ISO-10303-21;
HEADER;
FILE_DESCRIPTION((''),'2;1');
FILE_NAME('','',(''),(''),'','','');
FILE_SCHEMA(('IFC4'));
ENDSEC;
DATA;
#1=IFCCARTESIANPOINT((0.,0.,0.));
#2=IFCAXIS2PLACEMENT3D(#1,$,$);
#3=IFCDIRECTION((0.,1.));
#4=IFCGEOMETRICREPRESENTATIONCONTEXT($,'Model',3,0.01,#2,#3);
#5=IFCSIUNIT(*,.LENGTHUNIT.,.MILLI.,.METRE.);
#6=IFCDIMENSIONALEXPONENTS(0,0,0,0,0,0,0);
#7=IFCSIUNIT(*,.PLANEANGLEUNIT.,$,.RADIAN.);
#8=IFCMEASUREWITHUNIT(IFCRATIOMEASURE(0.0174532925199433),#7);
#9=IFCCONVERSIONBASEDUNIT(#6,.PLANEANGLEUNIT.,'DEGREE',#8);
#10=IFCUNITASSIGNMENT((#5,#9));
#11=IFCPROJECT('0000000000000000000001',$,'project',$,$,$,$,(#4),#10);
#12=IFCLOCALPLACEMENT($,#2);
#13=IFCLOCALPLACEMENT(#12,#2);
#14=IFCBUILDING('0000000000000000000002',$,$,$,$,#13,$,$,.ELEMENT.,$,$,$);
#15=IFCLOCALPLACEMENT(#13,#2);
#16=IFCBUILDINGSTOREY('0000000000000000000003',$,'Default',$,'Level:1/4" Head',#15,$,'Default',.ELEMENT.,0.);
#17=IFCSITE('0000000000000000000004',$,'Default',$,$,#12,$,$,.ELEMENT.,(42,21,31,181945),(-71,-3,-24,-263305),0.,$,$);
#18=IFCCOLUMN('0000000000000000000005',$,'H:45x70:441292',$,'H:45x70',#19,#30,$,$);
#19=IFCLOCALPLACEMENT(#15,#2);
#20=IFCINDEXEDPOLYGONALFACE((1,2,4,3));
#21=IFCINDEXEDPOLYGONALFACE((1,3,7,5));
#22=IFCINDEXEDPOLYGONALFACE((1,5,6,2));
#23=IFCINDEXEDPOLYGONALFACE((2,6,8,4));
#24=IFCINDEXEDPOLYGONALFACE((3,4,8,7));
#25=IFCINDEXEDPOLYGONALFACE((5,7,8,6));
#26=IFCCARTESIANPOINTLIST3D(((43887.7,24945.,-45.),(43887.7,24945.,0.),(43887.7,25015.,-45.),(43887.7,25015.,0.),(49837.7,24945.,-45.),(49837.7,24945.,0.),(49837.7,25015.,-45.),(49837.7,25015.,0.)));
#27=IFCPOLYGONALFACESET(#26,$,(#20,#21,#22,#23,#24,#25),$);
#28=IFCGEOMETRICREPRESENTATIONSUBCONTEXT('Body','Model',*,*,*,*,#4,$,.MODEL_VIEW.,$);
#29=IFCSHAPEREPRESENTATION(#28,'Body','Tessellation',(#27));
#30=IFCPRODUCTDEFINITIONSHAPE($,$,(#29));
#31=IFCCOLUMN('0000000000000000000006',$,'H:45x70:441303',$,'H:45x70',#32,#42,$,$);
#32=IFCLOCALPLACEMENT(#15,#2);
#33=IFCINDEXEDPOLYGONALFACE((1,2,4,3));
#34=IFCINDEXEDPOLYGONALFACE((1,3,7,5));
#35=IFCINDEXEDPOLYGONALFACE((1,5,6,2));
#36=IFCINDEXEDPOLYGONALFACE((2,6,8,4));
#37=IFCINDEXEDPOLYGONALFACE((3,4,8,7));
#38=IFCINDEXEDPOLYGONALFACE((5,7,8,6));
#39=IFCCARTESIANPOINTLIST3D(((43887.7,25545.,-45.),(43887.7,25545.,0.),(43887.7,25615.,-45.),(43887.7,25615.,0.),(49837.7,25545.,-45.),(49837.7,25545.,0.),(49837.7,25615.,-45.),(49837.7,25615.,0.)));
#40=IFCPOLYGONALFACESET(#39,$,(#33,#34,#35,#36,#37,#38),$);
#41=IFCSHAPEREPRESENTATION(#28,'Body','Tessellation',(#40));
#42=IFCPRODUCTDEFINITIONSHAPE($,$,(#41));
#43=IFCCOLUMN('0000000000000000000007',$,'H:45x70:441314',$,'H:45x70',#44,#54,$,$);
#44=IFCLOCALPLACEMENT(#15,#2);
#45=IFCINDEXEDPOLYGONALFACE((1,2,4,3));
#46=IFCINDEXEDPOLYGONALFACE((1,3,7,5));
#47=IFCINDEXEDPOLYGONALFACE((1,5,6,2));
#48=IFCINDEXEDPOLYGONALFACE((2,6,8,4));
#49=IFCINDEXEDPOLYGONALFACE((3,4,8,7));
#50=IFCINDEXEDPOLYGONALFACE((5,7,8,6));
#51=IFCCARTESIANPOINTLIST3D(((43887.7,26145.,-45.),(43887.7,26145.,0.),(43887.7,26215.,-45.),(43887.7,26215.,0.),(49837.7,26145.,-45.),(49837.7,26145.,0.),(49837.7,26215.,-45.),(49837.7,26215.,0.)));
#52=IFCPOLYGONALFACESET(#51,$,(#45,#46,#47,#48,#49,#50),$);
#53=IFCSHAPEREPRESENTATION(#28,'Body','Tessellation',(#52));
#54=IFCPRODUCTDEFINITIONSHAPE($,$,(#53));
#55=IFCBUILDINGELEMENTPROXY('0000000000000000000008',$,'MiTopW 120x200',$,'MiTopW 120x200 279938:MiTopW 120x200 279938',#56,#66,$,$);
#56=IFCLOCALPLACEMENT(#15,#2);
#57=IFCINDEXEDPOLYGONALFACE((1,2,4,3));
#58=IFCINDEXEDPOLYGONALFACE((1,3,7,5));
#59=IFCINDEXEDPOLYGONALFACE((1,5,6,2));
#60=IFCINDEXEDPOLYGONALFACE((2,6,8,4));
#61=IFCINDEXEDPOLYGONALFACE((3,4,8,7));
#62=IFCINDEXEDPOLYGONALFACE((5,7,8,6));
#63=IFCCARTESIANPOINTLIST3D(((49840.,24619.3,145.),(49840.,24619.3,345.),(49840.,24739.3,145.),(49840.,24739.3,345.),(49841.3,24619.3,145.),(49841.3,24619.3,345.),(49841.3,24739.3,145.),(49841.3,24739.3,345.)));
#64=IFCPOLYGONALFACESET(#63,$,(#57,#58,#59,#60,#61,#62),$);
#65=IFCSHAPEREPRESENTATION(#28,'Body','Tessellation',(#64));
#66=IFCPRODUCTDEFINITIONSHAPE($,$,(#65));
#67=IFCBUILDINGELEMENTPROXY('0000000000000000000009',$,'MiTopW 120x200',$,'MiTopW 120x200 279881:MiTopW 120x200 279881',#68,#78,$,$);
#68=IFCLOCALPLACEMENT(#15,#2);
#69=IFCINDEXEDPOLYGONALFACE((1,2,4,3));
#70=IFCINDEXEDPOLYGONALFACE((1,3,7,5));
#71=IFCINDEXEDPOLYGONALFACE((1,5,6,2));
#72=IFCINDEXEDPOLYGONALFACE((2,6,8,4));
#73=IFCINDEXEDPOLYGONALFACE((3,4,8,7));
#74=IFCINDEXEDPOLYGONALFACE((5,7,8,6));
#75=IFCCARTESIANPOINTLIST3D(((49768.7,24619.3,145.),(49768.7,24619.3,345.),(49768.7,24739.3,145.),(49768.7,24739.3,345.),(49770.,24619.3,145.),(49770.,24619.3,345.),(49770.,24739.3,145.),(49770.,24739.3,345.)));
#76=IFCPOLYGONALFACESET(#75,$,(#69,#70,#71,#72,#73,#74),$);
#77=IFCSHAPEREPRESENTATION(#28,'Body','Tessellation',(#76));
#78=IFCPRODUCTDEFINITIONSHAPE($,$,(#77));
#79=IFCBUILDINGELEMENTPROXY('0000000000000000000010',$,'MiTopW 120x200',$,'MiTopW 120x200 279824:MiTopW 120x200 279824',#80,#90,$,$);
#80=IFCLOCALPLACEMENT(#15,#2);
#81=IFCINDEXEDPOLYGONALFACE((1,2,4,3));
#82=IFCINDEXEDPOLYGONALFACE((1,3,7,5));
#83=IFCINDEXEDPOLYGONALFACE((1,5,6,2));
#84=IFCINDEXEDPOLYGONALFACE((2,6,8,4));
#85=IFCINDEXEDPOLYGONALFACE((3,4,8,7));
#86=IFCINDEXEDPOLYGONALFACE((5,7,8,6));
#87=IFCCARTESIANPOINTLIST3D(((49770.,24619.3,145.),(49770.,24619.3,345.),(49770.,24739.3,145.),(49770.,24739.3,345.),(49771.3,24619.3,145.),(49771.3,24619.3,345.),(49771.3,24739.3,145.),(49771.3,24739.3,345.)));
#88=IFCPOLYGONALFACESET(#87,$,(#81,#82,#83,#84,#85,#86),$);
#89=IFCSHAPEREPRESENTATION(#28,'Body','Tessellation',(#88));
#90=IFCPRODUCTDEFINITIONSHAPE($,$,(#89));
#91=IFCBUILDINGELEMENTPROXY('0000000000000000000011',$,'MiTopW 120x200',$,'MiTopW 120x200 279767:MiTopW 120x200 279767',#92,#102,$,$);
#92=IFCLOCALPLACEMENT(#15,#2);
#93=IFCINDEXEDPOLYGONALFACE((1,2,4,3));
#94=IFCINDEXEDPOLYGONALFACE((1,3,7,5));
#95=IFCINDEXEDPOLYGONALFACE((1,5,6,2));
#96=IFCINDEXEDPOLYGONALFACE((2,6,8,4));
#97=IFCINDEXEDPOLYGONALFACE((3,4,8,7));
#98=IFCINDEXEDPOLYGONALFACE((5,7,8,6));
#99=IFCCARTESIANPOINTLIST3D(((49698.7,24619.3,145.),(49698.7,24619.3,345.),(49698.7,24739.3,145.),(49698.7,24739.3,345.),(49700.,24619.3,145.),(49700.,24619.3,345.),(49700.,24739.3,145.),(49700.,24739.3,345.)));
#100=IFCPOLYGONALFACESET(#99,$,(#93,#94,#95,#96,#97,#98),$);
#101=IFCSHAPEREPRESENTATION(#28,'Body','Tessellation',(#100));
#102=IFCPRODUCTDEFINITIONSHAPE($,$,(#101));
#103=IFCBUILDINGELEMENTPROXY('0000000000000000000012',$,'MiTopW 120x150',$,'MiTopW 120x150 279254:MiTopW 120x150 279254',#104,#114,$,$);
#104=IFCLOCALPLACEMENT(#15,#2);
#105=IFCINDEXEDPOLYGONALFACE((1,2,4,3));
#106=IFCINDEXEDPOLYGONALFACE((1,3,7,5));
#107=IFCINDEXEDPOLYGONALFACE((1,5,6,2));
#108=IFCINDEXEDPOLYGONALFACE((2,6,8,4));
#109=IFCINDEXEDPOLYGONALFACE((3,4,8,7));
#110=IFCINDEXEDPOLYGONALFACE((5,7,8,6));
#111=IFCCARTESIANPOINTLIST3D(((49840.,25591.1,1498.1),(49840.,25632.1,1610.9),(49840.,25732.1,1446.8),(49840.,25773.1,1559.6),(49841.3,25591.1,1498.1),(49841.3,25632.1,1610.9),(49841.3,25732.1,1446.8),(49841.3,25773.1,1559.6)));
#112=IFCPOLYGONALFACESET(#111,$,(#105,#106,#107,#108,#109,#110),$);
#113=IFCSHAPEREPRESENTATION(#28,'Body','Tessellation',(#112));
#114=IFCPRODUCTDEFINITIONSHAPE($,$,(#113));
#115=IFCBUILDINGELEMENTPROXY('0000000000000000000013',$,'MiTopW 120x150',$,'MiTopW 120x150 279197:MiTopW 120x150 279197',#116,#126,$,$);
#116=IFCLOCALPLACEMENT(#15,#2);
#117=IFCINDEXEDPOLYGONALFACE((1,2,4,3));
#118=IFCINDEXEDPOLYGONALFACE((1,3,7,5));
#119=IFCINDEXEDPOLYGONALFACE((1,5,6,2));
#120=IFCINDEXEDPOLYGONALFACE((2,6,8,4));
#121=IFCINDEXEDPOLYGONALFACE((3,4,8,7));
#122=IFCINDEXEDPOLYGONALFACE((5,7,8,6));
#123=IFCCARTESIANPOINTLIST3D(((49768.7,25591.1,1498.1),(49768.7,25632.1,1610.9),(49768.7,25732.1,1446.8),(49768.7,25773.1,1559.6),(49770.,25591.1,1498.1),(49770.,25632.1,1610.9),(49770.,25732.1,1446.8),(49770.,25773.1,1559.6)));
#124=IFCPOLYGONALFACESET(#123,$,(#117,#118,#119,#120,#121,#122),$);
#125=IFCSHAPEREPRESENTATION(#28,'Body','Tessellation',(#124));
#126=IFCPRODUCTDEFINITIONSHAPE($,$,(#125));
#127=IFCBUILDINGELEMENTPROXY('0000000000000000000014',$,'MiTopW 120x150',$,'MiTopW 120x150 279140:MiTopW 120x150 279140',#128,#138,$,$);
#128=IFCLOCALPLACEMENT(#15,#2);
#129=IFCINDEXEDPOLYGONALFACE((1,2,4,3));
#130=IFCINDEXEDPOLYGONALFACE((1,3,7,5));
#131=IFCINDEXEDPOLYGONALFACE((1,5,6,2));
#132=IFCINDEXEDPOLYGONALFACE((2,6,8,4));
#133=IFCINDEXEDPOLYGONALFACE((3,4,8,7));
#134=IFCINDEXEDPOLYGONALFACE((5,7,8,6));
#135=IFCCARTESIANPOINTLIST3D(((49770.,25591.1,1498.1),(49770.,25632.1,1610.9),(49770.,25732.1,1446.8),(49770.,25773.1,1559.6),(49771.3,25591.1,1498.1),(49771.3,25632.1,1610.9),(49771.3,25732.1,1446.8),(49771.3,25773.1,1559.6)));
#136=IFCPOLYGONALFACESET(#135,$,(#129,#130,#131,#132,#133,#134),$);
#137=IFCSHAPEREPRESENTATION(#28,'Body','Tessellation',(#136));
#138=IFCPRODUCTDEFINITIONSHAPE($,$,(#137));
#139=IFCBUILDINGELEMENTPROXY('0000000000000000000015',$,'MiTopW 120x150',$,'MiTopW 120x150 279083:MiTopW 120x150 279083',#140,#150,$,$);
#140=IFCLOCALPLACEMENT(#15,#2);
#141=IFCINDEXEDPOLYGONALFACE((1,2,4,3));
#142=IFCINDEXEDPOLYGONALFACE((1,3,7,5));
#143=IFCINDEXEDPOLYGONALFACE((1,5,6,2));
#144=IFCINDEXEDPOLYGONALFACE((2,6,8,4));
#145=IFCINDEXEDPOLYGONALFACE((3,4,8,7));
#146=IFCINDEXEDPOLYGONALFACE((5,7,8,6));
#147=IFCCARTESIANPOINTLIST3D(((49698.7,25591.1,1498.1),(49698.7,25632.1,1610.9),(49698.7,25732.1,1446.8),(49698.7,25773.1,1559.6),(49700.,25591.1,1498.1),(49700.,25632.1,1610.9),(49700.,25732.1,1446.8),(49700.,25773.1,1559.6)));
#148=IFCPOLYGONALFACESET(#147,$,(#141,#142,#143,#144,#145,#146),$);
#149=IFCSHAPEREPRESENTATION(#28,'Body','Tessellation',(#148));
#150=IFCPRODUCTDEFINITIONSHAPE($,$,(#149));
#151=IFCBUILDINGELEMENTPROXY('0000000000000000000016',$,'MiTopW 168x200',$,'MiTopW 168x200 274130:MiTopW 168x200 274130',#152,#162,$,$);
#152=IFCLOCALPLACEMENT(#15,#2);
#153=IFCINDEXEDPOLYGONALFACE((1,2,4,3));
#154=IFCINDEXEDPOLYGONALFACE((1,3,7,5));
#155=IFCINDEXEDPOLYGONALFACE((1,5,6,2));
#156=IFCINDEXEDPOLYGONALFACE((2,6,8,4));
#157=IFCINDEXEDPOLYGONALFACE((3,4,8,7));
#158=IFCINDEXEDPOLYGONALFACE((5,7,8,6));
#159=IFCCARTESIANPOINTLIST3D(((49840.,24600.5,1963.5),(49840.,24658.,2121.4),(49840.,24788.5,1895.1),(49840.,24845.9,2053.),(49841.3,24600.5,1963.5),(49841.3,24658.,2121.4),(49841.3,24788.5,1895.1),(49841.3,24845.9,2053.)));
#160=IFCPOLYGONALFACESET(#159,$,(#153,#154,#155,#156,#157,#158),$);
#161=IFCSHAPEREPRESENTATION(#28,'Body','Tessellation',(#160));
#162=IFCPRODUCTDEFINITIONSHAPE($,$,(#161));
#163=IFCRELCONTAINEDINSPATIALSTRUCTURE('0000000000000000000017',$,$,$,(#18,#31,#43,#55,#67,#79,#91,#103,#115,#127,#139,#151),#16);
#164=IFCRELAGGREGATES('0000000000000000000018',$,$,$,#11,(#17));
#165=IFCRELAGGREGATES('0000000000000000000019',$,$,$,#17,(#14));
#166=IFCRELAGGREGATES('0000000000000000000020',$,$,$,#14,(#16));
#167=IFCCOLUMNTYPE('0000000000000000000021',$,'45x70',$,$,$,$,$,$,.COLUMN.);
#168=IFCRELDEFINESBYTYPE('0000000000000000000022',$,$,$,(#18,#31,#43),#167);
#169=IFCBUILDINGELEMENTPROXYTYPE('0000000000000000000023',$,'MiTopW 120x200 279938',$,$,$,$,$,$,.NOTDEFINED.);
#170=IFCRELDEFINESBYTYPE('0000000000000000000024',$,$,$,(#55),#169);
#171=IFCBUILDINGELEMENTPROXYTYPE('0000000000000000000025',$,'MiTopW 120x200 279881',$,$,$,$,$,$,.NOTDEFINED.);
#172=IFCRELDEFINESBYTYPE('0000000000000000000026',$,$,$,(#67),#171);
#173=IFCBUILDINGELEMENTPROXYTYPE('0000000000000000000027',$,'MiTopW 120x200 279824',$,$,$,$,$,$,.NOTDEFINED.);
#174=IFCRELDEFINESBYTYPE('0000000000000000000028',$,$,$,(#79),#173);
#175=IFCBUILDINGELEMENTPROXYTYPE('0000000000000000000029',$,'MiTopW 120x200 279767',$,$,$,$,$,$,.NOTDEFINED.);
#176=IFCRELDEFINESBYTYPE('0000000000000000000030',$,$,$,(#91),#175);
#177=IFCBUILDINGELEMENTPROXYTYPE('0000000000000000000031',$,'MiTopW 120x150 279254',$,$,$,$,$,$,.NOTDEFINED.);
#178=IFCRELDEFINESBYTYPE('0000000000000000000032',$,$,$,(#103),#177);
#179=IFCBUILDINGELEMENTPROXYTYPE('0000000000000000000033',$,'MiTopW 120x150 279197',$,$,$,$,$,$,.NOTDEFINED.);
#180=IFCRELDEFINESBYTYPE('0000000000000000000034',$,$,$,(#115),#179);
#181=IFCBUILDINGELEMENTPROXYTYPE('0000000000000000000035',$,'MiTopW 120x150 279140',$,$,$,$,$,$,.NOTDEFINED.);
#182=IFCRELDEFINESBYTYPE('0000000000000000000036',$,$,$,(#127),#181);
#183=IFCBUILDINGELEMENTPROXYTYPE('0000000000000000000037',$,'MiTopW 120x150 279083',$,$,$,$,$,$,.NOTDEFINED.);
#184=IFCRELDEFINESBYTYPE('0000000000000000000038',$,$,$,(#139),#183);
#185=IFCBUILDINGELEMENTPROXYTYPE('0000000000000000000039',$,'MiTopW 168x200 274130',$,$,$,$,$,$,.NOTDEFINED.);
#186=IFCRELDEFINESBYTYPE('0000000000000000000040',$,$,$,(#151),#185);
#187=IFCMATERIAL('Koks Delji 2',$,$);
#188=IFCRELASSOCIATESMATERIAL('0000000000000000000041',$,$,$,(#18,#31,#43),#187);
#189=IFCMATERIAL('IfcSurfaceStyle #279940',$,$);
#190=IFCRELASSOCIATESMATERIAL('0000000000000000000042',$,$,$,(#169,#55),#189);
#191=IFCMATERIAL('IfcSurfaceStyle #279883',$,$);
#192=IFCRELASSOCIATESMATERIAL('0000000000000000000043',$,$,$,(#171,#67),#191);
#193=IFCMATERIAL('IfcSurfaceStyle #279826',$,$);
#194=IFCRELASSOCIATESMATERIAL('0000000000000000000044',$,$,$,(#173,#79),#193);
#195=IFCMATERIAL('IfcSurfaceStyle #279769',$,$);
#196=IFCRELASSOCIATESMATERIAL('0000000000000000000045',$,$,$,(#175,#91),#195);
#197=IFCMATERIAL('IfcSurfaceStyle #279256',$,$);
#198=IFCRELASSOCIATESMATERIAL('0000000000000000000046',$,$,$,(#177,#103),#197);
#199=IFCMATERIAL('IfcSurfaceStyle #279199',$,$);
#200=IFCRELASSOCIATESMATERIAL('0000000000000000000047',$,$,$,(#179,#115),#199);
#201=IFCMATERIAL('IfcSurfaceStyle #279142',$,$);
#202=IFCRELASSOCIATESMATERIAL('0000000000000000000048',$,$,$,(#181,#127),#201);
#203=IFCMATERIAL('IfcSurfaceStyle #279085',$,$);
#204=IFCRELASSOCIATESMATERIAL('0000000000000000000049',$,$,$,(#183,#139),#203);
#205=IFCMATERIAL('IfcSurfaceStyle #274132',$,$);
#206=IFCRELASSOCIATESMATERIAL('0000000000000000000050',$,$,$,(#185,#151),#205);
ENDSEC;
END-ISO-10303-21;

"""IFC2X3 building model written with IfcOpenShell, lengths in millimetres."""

from ifc_helpers import new_model, entity, si_unit, converted_unit, direction, frame, frame_2d, origin, origin_2d_with_axis, place, context, subcontext, project, spatial, polyline, rectangle, outline, extrude, source, transform, mapped, material, type_object, type_shapes, element, save


model = new_model("IFC2X3")

# Units and contexts
model_context = context("Model", 3, precision=0.01, world=origin(), true_north=direction((0.0, 1.0)))
body_context = subcontext(model_context, "Body", "Model", "MODEL_VIEW")
ifc_project = project(units=[si_unit("LENGTHUNIT", "METRE", prefix="MILLI"), converted_unit("PLANEANGLEUNIT", "DEGREE", entity("IfcRatioMeasure", 0.0174532925199433), si_unit("PLANEANGLEUNIT", "RADIAN"), dimensions=[0, 0, 0, 0, 0, 0, 0])], contexts=[model_context])

# Site, building, storey
site_placement = place(None, origin())
site = spatial("IfcSite", under=ifc_project, at=site_placement, Name="Default", CompositionType="ELEMENT", RefLatitude=(42, 21, 31, 181945), RefLongitude=(-71, -3, -24, -263305), RefElevation=0.0)
building_placement = place(site_placement, origin())
building = spatial("IfcBuilding", under=site, at=building_placement, CompositionType="ELEMENT")
storey_placement = place(building_placement, origin())
storey = spatial("IfcBuildingStorey", under=building, at=storey_placement, Name="Default", ObjectType="Level:1/4\" Head", LongName="Default", CompositionType="ELEMENT", Elevation=0.0)

# Columns
ifc_material_1 = material(Name="Koks Delji 2")
column_type = type_object("IfcColumnType", Name="45x70", PredefinedType="COLUMN")
shared_shape_1 = source(origin(), body_context, "Body", "SweptSolid", [
    extrude(rectangle(XDim=70.0, YDim=5950.0, at=frame_2d((0.0, 0.0), x_axis=(1.0, 0.0))), frame((2975.0, 237.8, 0.0), z_axis=(0.0, 0.0, 1.0), x_axis=(0.0, -1.0, 0.0)), (0.0, 0.0, 1.0), 45.0),
])
type_shapes(column_type, [shared_shape_1])
for number, where, z_axis, x_axis, name in (
    (1, (49837.7, 25217.8, -45.0), (0.0, 0.0, 1.0), (-1.0, 0.0, 0.0), "H:45x70:441292"),
    (2, (49837.7, 25817.8, -45.0), (0.0, 0.0, 1.0), (-1.0, 0.0, 0.0), "H:45x70:441303"),
    (3, (49837.7, 26417.8, -45.0), (0.0, 0.0, 1.0), (-1.0, 0.0, 0.0), "H:45x70:441314"),
):
    element("IfcColumn", number, at=place(storey_placement, frame(where, z_axis=z_axis, x_axis=x_axis)), inside=storey, type_object=column_type, material=ifc_material_1, Name=name, ObjectType="H:45x70", context=body_context, shape_type="MappedRepresentation", body=[
        mapped(shared_shape_1, transform((0.0, 0.0, 0.0), scale=1.0)),
    ])

# Building element proxies
ifc_material_2 = material(Name="IfcSurfaceStyle #279940")
building_element_proxy_type_1 = type_object("IfcBuildingElementProxyType", Name="MiTopW 120x200 279938", PredefinedType="NOTDEFINED", material=ifc_material_2)
shared_shape_2 = source(origin(), body_context, "Body", "SweptSolid", [
    extrude(rectangle(XDim=200.0, YDim=120.0, at=origin_2d_with_axis()), frame((100.0, 60.0, 0.0), z_axis=(0.0, 0.0, 1.0), x_axis=(-1.0, 0.0, 0.0)), (0.0, 0.0, 1.0), 1.3),
])
type_shapes(building_element_proxy_type_1, [shared_shape_2])
proxy_1_placement = place(building_placement, frame((49841.3, 24619.3, 145.0), z_axis=(-1.0, 0.0, 0.0), x_axis=(0.0, 0.0, 1.0)))
element("IfcBuildingElementProxy", 4, at=proxy_1_placement, inside=storey, type_object=building_element_proxy_type_1, material=ifc_material_2, Name="MiTopW 120x200", ObjectType="MiTopW 120x200 279938:MiTopW 120x200 279938", context=body_context, shape_type="MappedRepresentation", body=[
    mapped(shared_shape_2, transform((0.0, 0.0, 0.0), scale=1.0)),
])
ifc_material_3 = material(Name="IfcSurfaceStyle #279883")
building_element_proxy_type_2 = type_object("IfcBuildingElementProxyType", Name="MiTopW 120x200 279881", PredefinedType="NOTDEFINED", material=ifc_material_3)
shared_shape_3 = source(origin(), body_context, "Body", "SweptSolid", [
    extrude(rectangle(XDim=200.0, YDim=120.0, at=origin_2d_with_axis()), frame((100.0, 60.0, 0.0), z_axis=(0.0, 0.0, 1.0), x_axis=(-1.0, 0.0, 0.0)), (0.0, 0.0, 1.0), 1.3),
])
type_shapes(building_element_proxy_type_2, [shared_shape_3])
proxy_2_placement = place(building_placement, frame((49770.0, 24619.3, 145.0), z_axis=(-1.0, 0.0, 0.0), x_axis=(0.0, 0.0, 1.0)))
element("IfcBuildingElementProxy", 5, at=proxy_2_placement, inside=storey, type_object=building_element_proxy_type_2, material=ifc_material_3, Name="MiTopW 120x200", ObjectType="MiTopW 120x200 279881:MiTopW 120x200 279881", context=body_context, shape_type="MappedRepresentation", body=[
    mapped(shared_shape_3, transform((0.0, 0.0, 0.0), scale=1.0)),
])
ifc_material_4 = material(Name="IfcSurfaceStyle #279826")
building_element_proxy_type_3 = type_object("IfcBuildingElementProxyType", Name="MiTopW 120x200 279824", PredefinedType="NOTDEFINED", material=ifc_material_4)
shared_shape_4 = source(origin(), body_context, "Body", "SweptSolid", [
    extrude(rectangle(XDim=200.0, YDim=120.0, at=origin_2d_with_axis()), frame((100.0, 60.0, 0.0), z_axis=(0.0, 0.0, 1.0), x_axis=(-1.0, 0.0, 0.0)), (0.0, 0.0, 1.0), 1.3),
])
type_shapes(building_element_proxy_type_3, [shared_shape_4])
proxy_3_placement = place(building_placement, frame((49771.3, 24619.3, 145.0), z_axis=(-1.0, 0.0, 0.0), x_axis=(0.0, 0.0, 1.0)))
element("IfcBuildingElementProxy", 6, at=proxy_3_placement, inside=storey, type_object=building_element_proxy_type_3, material=ifc_material_4, Name="MiTopW 120x200", ObjectType="MiTopW 120x200 279824:MiTopW 120x200 279824", context=body_context, shape_type="MappedRepresentation", body=[
    mapped(shared_shape_4, transform((0.0, 0.0, 0.0), scale=1.0)),
])
ifc_material_5 = material(Name="IfcSurfaceStyle #279769")
building_element_proxy_type_4 = type_object("IfcBuildingElementProxyType", Name="MiTopW 120x200 279767", PredefinedType="NOTDEFINED", material=ifc_material_5)
shared_shape_5 = source(origin(), body_context, "Body", "SweptSolid", [
    extrude(rectangle(XDim=200.0, YDim=120.0, at=origin_2d_with_axis()), frame((100.0, 60.0, 0.0), z_axis=(0.0, 0.0, 1.0), x_axis=(-1.0, 0.0, 0.0)), (0.0, 0.0, 1.0), 1.3),
])
type_shapes(building_element_proxy_type_4, [shared_shape_5])
proxy_4_placement = place(building_placement, frame((49700.0, 24619.3, 145.0), z_axis=(-1.0, 0.0, 0.0), x_axis=(0.0, 0.0, 1.0)))
element("IfcBuildingElementProxy", 7, at=proxy_4_placement, inside=storey, type_object=building_element_proxy_type_4, material=ifc_material_5, Name="MiTopW 120x200", ObjectType="MiTopW 120x200 279767:MiTopW 120x200 279767", context=body_context, shape_type="MappedRepresentation", body=[
    mapped(shared_shape_5, transform((0.0, 0.0, 0.0), scale=1.0)),
])
ifc_material_6 = material(Name="IfcSurfaceStyle #279256")
building_element_proxy_type_5 = type_object("IfcBuildingElementProxyType", Name="MiTopW 120x150 279254", PredefinedType="NOTDEFINED", material=ifc_material_6)
shared_shape_6 = source(origin(), body_context, "Body", "SweptSolid", [
    extrude(outline(polyline([(-75.0, -60.0), (75.0, -60.0), (75.0, 60.0), (-75.0, 60.0), (-75.0, -60.0)])), frame((75.0, 60.0, 0.0), z_axis=(0.0, 0.0, 1.0), x_axis=(-1.0, 0.0, 0.0)), (0.0, 0.0, 1.0), 1.3),
])
type_shapes(building_element_proxy_type_5, [shared_shape_6])
proxy_5_placement = place(building_placement, frame((49841.3, 25732.1, 1446.8), z_axis=(-1.0, 0.0, 0.0), x_axis=(0.0, -0.939693, 0.34202)))
element("IfcBuildingElementProxy", 8, at=proxy_5_placement, inside=storey, type_object=building_element_proxy_type_5, material=ifc_material_6, Name="MiTopW 120x150", ObjectType="MiTopW 120x150 279254:MiTopW 120x150 279254", context=body_context, shape_type="MappedRepresentation", body=[
    mapped(shared_shape_6, transform((0.0, 0.0, 0.0), scale=1.0)),
])
ifc_material_7 = material(Name="IfcSurfaceStyle #279199")
building_element_proxy_type_6 = type_object("IfcBuildingElementProxyType", Name="MiTopW 120x150 279197", PredefinedType="NOTDEFINED", material=ifc_material_7)
shared_shape_7 = source(origin(), body_context, "Body", "SweptSolid", [
    extrude(outline(polyline([(-75.0, -60.0), (75.0, -60.0), (75.0, 60.0), (-75.0, 60.0), (-75.0, -60.0)])), frame((75.0, 60.0, 0.0), z_axis=(0.0, 0.0, 1.0), x_axis=(-1.0, 0.0, 0.0)), (0.0, 0.0, 1.0), 1.3),
])
type_shapes(building_element_proxy_type_6, [shared_shape_7])
proxy_6_placement = place(building_placement, frame((49770.0, 25732.1, 1446.8), z_axis=(-1.0, 0.0, 0.0), x_axis=(0.0, -0.939693, 0.34202)))
element("IfcBuildingElementProxy", 9, at=proxy_6_placement, inside=storey, type_object=building_element_proxy_type_6, material=ifc_material_7, Name="MiTopW 120x150", ObjectType="MiTopW 120x150 279197:MiTopW 120x150 279197", context=body_context, shape_type="MappedRepresentation", body=[
    mapped(shared_shape_7, transform((0.0, 0.0, 0.0), scale=1.0)),
])
ifc_material_8 = material(Name="IfcSurfaceStyle #279142")
building_element_proxy_type_7 = type_object("IfcBuildingElementProxyType", Name="MiTopW 120x150 279140", PredefinedType="NOTDEFINED", material=ifc_material_8)
shared_shape_8 = source(origin(), body_context, "Body", "SweptSolid", [
    extrude(outline(polyline([(-75.0, -60.0), (75.0, -60.0), (75.0, 60.0), (-75.0, 60.0), (-75.0, -60.0)])), frame((75.0, 60.0, 0.0), z_axis=(0.0, 0.0, 1.0), x_axis=(-1.0, 0.0, 0.0)), (0.0, 0.0, 1.0), 1.3),
])
type_shapes(building_element_proxy_type_7, [shared_shape_8])
proxy_7_placement = place(building_placement, frame((49771.3, 25732.1, 1446.8), z_axis=(-1.0, 0.0, 0.0), x_axis=(0.0, -0.939693, 0.34202)))
element("IfcBuildingElementProxy", 10, at=proxy_7_placement, inside=storey, type_object=building_element_proxy_type_7, material=ifc_material_8, Name="MiTopW 120x150", ObjectType="MiTopW 120x150 279140:MiTopW 120x150 279140", context=body_context, shape_type="MappedRepresentation", body=[
    mapped(shared_shape_8, transform((0.0, 0.0, 0.0), scale=1.0)),
])
ifc_material_9 = material(Name="IfcSurfaceStyle #279085")
building_element_proxy_type_8 = type_object("IfcBuildingElementProxyType", Name="MiTopW 120x150 279083", PredefinedType="NOTDEFINED", material=ifc_material_9)
shared_shape_9 = source(origin(), body_context, "Body", "SweptSolid", [
    extrude(outline(polyline([(-75.0, -60.0), (75.0, -60.0), (75.0, 60.0), (-75.0, 60.0), (-75.0, -60.0)])), frame((75.0, 60.0, 0.0), z_axis=(0.0, 0.0, 1.0), x_axis=(-1.0, 0.0, 0.0)), (0.0, 0.0, 1.0), 1.3),
])
type_shapes(building_element_proxy_type_8, [shared_shape_9])
proxy_8_placement = place(building_placement, frame((49700.0, 25732.1, 1446.8), z_axis=(-1.0, 0.0, 0.0), x_axis=(0.0, -0.939693, 0.34202)))
element("IfcBuildingElementProxy", 11, at=proxy_8_placement, inside=storey, type_object=building_element_proxy_type_8, material=ifc_material_9, Name="MiTopW 120x150", ObjectType="MiTopW 120x150 279083:MiTopW 120x150 279083", context=body_context, shape_type="MappedRepresentation", body=[
    mapped(shared_shape_9, transform((0.0, 0.0, 0.0), scale=1.0)),
])
ifc_material_10 = material(Name="IfcSurfaceStyle #274132")
building_element_proxy_type_9 = type_object("IfcBuildingElementProxyType", Name="MiTopW 168x200 274130", PredefinedType="NOTDEFINED", material=ifc_material_10)
shared_shape_10 = source(origin(), body_context, "Body", "SweptSolid", [
    extrude(outline(polyline([(-100.0, -84.0), (100.0, -84.0), (100.0, 84.0), (-100.0, 84.0), (-100.0, -84.0)])), frame((100.0, 84.0, 0.0), z_axis=(0.0, 0.0, 1.0), x_axis=(-1.0, 0.0, 0.0)), (0.0, 0.0, 1.0), 1.3),
])
type_shapes(building_element_proxy_type_9, [shared_shape_10])
proxy_9_placement = place(building_placement, frame((49841.3, 24788.5, 1895.1), z_axis=(-1.0, 0.0, 0.0), x_axis=(0.0, -0.939693, 0.34202)))
element("IfcBuildingElementProxy", 12, at=proxy_9_placement, inside=storey, type_object=building_element_proxy_type_9, material=ifc_material_10, Name="MiTopW 168x200", ObjectType="MiTopW 168x200 274130:MiTopW 168x200 274130", context=body_context, shape_type="MappedRepresentation", body=[
    mapped(shared_shape_10, transform((0.0, 0.0, 0.0), scale=1.0)),
])

save(model, "model.ifc")
